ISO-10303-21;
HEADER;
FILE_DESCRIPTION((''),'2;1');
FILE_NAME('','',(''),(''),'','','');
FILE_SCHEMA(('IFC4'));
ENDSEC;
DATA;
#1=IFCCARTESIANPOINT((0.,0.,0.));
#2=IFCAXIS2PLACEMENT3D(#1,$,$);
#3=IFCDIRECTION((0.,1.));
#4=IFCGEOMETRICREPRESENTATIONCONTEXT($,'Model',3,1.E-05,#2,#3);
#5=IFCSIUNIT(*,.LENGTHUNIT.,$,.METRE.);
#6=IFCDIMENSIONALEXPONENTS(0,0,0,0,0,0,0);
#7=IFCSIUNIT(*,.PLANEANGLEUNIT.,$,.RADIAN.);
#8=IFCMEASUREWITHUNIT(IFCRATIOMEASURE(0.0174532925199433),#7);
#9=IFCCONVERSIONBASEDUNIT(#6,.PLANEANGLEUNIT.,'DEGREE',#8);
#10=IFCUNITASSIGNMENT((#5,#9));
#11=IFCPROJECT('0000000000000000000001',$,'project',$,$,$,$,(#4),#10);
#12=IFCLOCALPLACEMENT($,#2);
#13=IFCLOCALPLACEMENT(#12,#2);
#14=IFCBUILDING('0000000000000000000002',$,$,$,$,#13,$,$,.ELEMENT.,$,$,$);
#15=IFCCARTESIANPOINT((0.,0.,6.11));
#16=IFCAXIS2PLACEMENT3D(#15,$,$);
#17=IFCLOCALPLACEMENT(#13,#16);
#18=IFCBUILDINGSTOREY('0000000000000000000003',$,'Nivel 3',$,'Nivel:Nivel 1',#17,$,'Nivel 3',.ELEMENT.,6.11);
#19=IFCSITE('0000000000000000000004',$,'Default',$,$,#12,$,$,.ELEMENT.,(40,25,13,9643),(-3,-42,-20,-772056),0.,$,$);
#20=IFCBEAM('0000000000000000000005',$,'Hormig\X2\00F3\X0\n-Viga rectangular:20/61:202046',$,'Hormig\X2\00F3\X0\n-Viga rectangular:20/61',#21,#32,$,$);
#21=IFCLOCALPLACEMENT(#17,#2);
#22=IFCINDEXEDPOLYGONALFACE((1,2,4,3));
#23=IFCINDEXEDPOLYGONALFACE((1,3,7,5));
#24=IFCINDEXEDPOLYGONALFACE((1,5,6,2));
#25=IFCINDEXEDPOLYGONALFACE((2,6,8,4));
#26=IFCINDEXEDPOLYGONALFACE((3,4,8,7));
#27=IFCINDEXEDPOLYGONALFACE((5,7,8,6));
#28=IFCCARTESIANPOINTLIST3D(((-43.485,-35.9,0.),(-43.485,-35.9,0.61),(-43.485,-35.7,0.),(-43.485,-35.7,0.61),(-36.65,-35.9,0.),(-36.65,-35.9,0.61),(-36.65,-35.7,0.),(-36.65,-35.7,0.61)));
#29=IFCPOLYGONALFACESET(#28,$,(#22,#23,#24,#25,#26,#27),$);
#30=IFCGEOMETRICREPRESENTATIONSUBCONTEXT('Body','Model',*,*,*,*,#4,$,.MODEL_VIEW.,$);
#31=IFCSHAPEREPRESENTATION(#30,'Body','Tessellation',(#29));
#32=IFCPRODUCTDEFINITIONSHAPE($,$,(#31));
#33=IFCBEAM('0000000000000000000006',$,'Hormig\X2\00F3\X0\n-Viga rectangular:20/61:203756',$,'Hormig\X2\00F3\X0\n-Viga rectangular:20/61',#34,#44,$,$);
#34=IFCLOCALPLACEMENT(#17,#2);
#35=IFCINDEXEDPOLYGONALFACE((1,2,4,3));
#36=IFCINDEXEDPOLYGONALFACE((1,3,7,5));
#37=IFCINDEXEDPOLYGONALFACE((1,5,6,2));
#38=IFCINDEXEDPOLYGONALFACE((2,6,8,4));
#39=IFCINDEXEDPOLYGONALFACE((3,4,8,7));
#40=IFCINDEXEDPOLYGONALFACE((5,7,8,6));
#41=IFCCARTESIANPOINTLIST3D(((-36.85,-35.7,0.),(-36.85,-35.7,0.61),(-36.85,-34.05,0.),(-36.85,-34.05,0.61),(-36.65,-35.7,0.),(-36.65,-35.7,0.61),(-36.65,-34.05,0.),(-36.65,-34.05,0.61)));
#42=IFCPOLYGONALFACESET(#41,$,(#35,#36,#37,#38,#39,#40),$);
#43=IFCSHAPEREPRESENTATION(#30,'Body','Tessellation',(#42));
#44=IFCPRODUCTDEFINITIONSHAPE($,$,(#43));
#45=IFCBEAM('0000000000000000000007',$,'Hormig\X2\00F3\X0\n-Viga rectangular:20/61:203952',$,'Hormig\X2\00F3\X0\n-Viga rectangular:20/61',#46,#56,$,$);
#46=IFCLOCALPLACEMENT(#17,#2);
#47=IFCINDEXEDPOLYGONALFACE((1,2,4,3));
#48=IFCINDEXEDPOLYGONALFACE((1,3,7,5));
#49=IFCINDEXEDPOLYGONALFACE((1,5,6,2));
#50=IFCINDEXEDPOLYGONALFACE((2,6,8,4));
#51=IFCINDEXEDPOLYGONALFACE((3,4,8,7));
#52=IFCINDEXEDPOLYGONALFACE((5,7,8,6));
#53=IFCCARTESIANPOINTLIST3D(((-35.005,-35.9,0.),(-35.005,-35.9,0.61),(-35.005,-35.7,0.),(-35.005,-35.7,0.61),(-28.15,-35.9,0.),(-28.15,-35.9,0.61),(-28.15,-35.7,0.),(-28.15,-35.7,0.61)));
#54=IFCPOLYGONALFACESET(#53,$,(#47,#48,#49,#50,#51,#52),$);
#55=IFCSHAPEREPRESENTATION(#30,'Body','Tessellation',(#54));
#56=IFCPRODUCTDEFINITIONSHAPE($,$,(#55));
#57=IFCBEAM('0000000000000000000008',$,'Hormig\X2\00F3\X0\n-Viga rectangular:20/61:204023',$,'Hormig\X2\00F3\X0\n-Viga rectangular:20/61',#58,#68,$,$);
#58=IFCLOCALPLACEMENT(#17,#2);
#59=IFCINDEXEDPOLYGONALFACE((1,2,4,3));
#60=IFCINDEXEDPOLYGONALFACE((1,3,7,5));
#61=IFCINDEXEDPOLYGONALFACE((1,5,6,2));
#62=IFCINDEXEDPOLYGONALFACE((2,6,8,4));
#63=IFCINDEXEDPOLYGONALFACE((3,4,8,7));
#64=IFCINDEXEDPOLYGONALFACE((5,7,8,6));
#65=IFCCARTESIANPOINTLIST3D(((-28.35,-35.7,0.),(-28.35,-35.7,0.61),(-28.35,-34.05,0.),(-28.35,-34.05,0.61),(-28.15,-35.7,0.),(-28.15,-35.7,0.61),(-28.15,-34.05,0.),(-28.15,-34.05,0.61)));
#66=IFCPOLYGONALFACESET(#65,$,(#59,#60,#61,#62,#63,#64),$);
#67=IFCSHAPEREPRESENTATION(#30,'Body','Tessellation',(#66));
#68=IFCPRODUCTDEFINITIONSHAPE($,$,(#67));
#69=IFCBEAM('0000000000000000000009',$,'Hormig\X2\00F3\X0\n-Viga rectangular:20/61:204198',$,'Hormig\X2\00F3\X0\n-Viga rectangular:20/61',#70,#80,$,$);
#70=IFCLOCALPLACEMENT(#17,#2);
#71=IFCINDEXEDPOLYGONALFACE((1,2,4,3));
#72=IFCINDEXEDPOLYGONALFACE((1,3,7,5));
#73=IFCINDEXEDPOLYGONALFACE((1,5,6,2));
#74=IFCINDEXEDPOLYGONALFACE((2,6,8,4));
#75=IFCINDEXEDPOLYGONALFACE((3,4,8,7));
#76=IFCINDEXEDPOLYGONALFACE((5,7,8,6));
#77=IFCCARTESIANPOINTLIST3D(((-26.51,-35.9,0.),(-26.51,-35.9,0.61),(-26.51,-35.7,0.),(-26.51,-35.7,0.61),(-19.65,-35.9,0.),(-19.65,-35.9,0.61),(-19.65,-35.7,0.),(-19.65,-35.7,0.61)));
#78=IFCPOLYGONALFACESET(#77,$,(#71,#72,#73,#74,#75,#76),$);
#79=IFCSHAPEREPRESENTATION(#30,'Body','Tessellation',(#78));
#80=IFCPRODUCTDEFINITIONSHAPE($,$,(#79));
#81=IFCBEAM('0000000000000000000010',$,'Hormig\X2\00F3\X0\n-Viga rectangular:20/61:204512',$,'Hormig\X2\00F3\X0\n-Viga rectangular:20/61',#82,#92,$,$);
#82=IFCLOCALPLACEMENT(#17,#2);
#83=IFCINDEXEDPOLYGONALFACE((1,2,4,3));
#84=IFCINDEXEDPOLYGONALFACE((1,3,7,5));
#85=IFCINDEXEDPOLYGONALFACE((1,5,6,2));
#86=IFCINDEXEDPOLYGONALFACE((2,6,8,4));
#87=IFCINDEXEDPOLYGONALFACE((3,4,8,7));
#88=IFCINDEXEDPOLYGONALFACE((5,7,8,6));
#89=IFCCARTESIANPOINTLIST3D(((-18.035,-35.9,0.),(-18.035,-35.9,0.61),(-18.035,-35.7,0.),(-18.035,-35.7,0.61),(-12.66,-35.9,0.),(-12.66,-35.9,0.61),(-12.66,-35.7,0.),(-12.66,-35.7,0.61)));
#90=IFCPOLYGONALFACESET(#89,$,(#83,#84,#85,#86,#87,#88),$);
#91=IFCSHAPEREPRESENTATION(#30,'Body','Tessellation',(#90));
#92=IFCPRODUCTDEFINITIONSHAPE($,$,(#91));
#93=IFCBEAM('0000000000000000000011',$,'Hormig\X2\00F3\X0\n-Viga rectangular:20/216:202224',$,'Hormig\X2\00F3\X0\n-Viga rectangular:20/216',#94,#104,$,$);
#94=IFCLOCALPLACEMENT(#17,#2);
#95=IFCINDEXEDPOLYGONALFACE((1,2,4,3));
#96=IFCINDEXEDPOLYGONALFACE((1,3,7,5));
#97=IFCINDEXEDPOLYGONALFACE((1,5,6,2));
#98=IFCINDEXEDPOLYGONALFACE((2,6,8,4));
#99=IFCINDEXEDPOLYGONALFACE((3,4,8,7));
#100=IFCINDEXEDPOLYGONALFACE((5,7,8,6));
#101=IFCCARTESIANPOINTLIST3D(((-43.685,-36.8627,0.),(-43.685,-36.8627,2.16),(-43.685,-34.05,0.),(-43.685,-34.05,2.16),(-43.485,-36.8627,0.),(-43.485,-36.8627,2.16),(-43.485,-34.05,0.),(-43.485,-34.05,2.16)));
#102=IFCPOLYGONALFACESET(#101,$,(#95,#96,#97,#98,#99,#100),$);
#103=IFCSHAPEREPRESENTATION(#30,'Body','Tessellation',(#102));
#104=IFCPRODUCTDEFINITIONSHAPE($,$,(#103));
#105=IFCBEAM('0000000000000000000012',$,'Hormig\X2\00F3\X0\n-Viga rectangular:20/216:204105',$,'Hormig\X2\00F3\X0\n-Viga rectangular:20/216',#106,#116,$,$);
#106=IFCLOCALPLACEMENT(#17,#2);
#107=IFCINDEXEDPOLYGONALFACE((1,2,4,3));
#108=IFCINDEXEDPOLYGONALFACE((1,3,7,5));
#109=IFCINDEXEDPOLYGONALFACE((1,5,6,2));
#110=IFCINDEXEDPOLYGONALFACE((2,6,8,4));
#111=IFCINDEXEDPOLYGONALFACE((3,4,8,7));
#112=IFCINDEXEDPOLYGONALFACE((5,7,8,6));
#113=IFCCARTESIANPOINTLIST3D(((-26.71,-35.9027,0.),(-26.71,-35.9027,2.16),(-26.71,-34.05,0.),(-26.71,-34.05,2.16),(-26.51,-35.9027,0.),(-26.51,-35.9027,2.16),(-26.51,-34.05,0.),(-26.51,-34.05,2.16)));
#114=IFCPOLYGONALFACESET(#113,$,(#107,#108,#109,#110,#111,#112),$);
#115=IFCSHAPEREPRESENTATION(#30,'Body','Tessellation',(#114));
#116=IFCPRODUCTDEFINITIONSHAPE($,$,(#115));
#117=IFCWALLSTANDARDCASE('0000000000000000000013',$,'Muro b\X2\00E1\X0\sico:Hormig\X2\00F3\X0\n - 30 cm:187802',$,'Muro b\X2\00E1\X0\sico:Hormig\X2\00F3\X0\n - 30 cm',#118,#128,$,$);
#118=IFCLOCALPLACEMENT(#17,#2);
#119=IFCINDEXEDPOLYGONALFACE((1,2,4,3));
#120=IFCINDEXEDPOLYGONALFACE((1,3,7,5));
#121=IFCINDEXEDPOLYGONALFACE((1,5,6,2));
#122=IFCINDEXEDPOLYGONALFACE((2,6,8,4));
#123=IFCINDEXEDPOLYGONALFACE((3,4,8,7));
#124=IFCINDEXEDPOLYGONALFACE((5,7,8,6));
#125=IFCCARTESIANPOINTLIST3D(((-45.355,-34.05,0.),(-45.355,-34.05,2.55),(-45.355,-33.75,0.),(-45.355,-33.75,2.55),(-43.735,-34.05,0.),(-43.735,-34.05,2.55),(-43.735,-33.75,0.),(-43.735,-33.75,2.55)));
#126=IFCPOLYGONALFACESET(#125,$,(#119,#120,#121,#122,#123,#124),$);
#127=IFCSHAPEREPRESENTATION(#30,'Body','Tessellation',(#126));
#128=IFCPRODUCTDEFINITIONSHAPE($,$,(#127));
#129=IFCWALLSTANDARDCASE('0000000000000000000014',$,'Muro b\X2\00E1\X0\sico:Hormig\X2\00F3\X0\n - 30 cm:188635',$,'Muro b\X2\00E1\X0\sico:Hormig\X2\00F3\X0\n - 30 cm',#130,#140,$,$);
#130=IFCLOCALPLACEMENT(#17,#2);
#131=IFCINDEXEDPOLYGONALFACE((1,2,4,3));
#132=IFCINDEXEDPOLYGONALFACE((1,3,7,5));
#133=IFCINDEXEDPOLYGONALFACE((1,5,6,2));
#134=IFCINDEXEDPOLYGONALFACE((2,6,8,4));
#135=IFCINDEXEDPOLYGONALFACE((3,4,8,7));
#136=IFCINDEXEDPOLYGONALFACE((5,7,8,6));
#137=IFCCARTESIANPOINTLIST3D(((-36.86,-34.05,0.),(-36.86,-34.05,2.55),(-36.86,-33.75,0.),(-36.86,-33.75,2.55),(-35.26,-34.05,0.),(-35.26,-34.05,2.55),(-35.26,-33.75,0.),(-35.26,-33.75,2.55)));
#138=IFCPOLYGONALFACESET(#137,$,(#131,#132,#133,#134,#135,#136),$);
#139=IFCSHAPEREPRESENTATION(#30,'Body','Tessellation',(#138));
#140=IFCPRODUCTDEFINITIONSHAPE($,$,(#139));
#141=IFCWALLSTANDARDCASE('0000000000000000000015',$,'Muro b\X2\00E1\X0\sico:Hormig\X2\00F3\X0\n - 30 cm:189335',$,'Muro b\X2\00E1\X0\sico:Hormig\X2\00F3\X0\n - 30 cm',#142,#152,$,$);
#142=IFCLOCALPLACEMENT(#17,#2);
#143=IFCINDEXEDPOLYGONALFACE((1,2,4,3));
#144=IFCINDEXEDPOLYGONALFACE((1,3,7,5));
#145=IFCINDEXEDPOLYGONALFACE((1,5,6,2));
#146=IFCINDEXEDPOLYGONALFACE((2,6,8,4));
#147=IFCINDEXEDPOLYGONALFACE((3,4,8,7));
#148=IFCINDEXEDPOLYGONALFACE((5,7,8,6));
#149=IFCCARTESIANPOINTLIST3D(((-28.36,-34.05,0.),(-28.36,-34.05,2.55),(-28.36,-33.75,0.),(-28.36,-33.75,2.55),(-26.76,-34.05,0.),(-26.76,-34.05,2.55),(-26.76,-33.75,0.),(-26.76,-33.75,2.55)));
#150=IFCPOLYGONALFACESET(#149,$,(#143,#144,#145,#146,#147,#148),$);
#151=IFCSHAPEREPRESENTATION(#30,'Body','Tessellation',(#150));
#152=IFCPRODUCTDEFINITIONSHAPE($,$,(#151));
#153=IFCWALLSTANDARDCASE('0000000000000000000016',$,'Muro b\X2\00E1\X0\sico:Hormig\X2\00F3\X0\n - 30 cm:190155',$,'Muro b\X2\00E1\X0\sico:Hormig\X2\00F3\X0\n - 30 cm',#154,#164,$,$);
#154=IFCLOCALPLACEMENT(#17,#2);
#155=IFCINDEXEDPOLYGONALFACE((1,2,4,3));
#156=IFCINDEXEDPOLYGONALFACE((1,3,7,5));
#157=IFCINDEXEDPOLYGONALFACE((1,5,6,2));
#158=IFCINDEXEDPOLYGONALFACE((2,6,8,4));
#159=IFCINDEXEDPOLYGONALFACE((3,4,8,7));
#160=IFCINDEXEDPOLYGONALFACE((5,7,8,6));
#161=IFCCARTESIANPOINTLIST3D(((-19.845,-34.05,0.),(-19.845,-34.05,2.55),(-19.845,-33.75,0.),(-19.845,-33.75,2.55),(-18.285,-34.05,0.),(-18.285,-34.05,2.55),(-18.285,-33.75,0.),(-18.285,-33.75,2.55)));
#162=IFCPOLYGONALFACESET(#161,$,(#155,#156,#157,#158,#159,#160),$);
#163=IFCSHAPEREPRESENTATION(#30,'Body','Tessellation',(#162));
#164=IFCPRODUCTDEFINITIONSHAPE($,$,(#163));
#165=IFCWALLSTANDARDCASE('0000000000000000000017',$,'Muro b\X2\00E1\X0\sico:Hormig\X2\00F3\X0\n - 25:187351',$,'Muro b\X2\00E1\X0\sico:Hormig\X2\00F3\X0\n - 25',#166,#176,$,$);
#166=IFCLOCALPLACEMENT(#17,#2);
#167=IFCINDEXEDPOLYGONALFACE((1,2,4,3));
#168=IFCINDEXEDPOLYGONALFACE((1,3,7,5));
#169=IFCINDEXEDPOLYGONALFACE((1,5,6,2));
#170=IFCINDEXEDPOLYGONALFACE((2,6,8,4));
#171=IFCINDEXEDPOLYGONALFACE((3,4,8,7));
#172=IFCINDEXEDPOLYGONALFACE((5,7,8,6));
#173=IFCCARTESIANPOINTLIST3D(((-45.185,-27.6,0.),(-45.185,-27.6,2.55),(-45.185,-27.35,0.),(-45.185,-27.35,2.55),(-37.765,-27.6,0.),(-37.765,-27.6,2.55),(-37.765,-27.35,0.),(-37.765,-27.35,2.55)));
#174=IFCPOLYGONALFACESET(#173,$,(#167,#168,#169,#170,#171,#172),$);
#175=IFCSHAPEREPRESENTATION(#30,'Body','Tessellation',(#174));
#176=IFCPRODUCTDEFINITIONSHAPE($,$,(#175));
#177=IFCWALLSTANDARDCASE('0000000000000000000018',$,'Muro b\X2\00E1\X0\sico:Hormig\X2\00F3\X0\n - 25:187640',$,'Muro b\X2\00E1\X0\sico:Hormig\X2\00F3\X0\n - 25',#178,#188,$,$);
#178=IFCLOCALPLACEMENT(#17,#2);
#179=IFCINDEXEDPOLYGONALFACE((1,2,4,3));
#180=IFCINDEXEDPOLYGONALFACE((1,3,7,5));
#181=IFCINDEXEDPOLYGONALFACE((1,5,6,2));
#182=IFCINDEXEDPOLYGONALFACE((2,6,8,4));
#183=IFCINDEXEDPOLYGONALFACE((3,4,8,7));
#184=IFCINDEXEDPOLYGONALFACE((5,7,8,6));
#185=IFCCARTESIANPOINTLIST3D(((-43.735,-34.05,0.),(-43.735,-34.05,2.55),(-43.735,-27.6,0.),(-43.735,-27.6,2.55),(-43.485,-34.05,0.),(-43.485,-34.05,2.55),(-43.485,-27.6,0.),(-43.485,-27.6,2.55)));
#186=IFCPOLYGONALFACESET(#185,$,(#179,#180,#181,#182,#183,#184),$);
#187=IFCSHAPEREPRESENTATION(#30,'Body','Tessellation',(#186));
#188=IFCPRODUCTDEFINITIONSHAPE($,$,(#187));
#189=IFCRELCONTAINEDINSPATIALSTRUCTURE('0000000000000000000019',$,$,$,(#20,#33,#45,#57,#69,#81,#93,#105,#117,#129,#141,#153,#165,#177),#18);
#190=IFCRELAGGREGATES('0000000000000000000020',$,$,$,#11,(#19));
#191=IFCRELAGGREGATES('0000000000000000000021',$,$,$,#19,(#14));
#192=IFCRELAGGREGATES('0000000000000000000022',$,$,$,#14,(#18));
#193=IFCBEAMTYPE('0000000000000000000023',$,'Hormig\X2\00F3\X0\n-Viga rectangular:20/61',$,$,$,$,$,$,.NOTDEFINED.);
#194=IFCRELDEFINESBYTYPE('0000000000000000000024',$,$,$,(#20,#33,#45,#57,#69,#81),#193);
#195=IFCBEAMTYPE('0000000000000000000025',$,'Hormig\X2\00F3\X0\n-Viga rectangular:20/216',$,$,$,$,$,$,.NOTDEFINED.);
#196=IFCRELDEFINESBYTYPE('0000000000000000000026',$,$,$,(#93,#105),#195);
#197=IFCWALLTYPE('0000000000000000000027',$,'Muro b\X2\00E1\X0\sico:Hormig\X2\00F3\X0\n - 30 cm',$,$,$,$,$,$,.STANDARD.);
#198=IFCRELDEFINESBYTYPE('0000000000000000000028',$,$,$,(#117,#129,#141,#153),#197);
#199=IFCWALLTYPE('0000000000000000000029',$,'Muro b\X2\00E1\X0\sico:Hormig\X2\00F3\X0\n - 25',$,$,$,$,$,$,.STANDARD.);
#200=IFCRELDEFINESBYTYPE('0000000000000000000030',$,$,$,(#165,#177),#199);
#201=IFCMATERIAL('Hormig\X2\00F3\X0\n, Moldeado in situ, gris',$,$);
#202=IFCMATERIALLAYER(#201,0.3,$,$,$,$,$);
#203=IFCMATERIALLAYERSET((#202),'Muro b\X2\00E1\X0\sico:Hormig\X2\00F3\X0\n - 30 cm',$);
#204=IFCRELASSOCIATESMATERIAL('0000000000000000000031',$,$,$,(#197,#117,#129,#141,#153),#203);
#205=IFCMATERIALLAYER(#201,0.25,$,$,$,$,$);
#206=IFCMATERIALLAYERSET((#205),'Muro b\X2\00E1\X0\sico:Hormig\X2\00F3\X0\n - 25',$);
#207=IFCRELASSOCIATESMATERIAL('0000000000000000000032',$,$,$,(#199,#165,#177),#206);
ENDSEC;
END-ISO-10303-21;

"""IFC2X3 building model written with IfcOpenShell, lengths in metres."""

from ifc_helpers import new_model, entity, si_unit, converted_unit, direction, frame, frame_2d, origin, origin_2d_with_axis, place, context, subcontext, project, spatial, rectangle, extrude, material, layer, layer_set, layer_usage, type_object, element, save


model = new_model("IFC2X3")

# Units and contexts
model_context = context("Model", 3, precision=1e-05, world=origin(), true_north=direction((0.0, 1.0)))
body_context = subcontext(model_context, "Body", "Model", "MODEL_VIEW")
ifc_project = project(units=[si_unit("LENGTHUNIT", "METRE"), converted_unit("PLANEANGLEUNIT", "DEGREE", entity("IfcRatioMeasure", 0.0174532925199433), si_unit("PLANEANGLEUNIT", "RADIAN"), dimensions=[0, 0, 0, 0, 0, 0, 0])], contexts=[model_context])

# Site, building, storey
site_placement = place(None, origin())
site = spatial("IfcSite", under=ifc_project, at=site_placement, Name="Default", CompositionType="ELEMENT", RefLatitude=(40, 25, 13, 9643), RefLongitude=(-3, -42, -20, -772056), RefElevation=0.0)
building_placement = place(site_placement, origin())
building = spatial("IfcBuilding", under=site, at=building_placement, CompositionType="ELEMENT")
storey_placement = place(building_placement, frame((0.0, 0.0, 6.11)))
storey = spatial("IfcBuildingStorey", under=building, at=storey_placement, Name="Nivel 3", ObjectType="Nivel:Nivel 1", LongName="Nivel 3", CompositionType="ELEMENT", Elevation=6.11)

# Beams
beam_type_1 = type_object("IfcBeamType", Name="Hormigón-Viga rectangular:20/61", PredefinedType="NOTDEFINED")
beam_1_placement = place(storey_placement, frame((-43.585, -35.8, 0.61)))
element("IfcBeam", 1, at=beam_1_placement, inside=storey, type_object=beam_type_1, Name="Hormigón-Viga rectangular:20/61:202046", ObjectType="Hormigón-Viga rectangular:20/61", context=body_context, shape_type="SweptSolid", body=[
    extrude(rectangle(XDim=0.61, YDim=0.2, at=frame_2d((0.0, 0.0), x_axis=(1.0, 0.0))), frame((0.1, 0.0, -0.305), z_axis=(1.0, 0.0, 0.0), x_axis=(0.0, 0.0, -1.0)), (0.0, 0.0, 1.0), 6.835),
])
beam_2_placement = place(storey_placement, frame((-36.75, -35.8, 0.61), z_axis=(0.0, 0.0, 1.0), x_axis=(0.0, 1.0, 0.0)))
element("IfcBeam", 2, at=beam_2_placement, inside=storey, type_object=beam_type_1, Name="Hormigón-Viga rectangular:20/61:203756", ObjectType="Hormigón-Viga rectangular:20/61", context=body_context, shape_type="SweptSolid", body=[
    extrude(rectangle(XDim=0.61, YDim=0.2, at=frame_2d((0.0, 0.0), x_axis=(1.0, 0.0))), frame((0.1, 0.0, -0.305), z_axis=(1.0, 0.0, 0.0), x_axis=(0.0, 0.0, -1.0)), (0.0, 0.0, 1.0), 1.65),
])
beam_3_placement = place(storey_placement, frame((-35.105, -35.8, 0.61)))
element("IfcBeam", 3, at=beam_3_placement, inside=storey, type_object=beam_type_1, Name="Hormigón-Viga rectangular:20/61:203952", ObjectType="Hormigón-Viga rectangular:20/61", context=body_context, shape_type="SweptSolid", body=[
    extrude(rectangle(XDim=0.61, YDim=0.2, at=frame_2d((0.0, 0.0), x_axis=(1.0, 0.0))), frame((0.1, 0.0, -0.305), z_axis=(1.0, 0.0, 0.0), x_axis=(0.0, 0.0, -1.0)), (0.0, 0.0, 1.0), 6.855),
])
beam_4_placement = place(storey_placement, frame((-28.25, -35.8, 0.61), z_axis=(0.0, 0.0, 1.0), x_axis=(0.0, 1.0, 0.0)))
element("IfcBeam", 4, at=beam_4_placement, inside=storey, type_object=beam_type_1, Name="Hormigón-Viga rectangular:20/61:204023", ObjectType="Hormigón-Viga rectangular:20/61", context=body_context, shape_type="SweptSolid", body=[
    extrude(rectangle(XDim=0.61, YDim=0.2, at=frame_2d((0.0, 0.0), x_axis=(1.0, 0.0))), frame((0.1, 0.0, -0.305), z_axis=(1.0, 0.0, 0.0), x_axis=(0.0, 0.0, -1.0)), (0.0, 0.0, 1.0), 1.65),
])
beam_5_placement = place(storey_placement, frame((-26.5857, -35.8, 0.61)))
element("IfcBeam", 5, at=beam_5_placement, inside=storey, type_object=beam_type_1, Name="Hormigón-Viga rectangular:20/61:204198", ObjectType="Hormigón-Viga rectangular:20/61", context=body_context, shape_type="SweptSolid", body=[
    extrude(rectangle(XDim=0.61, YDim=0.2, at=frame_2d((0.0, 0.0), x_axis=(1.0, 0.0))), frame((0.0757, 0.0, -0.305), z_axis=(1.0, 0.0, 0.0), x_axis=(0.0, 0.0, -1.0)), (0.0, 0.0, 1.0), 6.86),
])
beam_6_placement = place(storey_placement, frame((-18.1107, -35.8, 0.61)))
element("IfcBeam", 6, at=beam_6_placement, inside=storey, type_object=beam_type_1, Name="Hormigón-Viga rectangular:20/61:204512", ObjectType="Hormigón-Viga rectangular:20/61", context=body_context, shape_type="SweptSolid", body=[
    extrude(rectangle(XDim=0.61, YDim=0.2, at=frame_2d((0.0, 0.0), x_axis=(1.0, 0.0))), frame((0.0757, 0.0, -0.305), z_axis=(1.0, 0.0, 0.0), x_axis=(0.0, 0.0, -1.0)), (0.0, 0.0, 1.0), 5.375),
])
beam_type_2 = type_object("IfcBeamType", Name="Hormigón-Viga rectangular:20/216", PredefinedType="NOTDEFINED")
beam_7_placement = place(storey_placement, frame((-43.585, -36.85, 2.16), z_axis=(0.0, 0.0, 1.0), x_axis=(0.0, 1.0, 0.0)))
element("IfcBeam", 7, at=beam_7_placement, inside=storey, type_object=beam_type_2, Name="Hormigón-Viga rectangular:20/216:202224", ObjectType="Hormigón-Viga rectangular:20/216", context=body_context, shape_type="SweptSolid", body=[
    extrude(rectangle(XDim=2.16, YDim=0.2, at=origin_2d_with_axis()), frame((-0.0127, 0.0, -1.08), z_axis=(1.0, 0.0, 0.0), x_axis=(0.0, 0.0, -1.0)), (0.0, 0.0, 1.0), 2.8127),
])
beam_8_placement = place(storey_placement, frame((-26.61, -35.89, 2.16), z_axis=(0.0, 0.0, 1.0), x_axis=(0.0, 1.0, 0.0)))
element("IfcBeam", 8, at=beam_8_placement, inside=storey, type_object=beam_type_2, Name="Hormigón-Viga rectangular:20/216:204105", ObjectType="Hormigón-Viga rectangular:20/216", context=body_context, shape_type="SweptSolid", body=[
    extrude(rectangle(XDim=2.16, YDim=0.2, at=frame_2d((0.0, 0.0), x_axis=(1.0, 0.0))), frame((-0.0127, 0.0, -1.08), z_axis=(1.0, 0.0, 0.0), x_axis=(0.0, 0.0, -1.0)), (0.0, 0.0, 1.0), 1.8527),
])

# Walls
ifc_material = material(Name="Hormigón, Moldeado in situ, gris")
ifc_layer_1 = layer(ifc_material, 0.3)
ifc_layer_set_1 = layer_set([ifc_layer_1], Name="Muro básico:Hormigón - 30 cm")
ifc_layer_usage_1 = layer_usage(ifc_layer_set_1, "AXIS2", "NEGATIVE", 0.15)
wall_type_1 = type_object("IfcWallType", Name="Muro básico:Hormigón - 30 cm", PredefinedType="STANDARD", material=ifc_layer_set_1)
wall_1_placement = place(storey_placement, frame((-43.735, -33.9, 0.0), z_axis=(0.0, 0.0, 1.0), x_axis=(-1.0, 0.0, 0.0)))
element("IfcWallStandardCase", 9, at=wall_1_placement, inside=storey, type_object=wall_type_1, material=ifc_layer_usage_1, Name="Muro básico:Hormigón - 30 cm:187802", ObjectType="Muro básico:Hormigón - 30 cm", context=body_context, shape_type="SweptSolid", body=[
    extrude(rectangle(XDim=1.62, YDim=0.3, at=frame_2d((0.81, 0.0), x_axis=(-1.0, 0.0))), origin(), (0.0, 0.0, 1.0), 2.55),
])
ifc_layer_usage_2 = layer_usage(ifc_layer_set_1, "AXIS2", "NEGATIVE", 0.15)
wall_2_placement = place(storey_placement, frame((-35.26, -33.9, 0.0), z_axis=(0.0, 0.0, 1.0), x_axis=(-1.0, 0.0, 0.0)))
element("IfcWallStandardCase", 10, at=wall_2_placement, inside=storey, type_object=wall_type_1, material=ifc_layer_usage_2, Name="Muro básico:Hormigón - 30 cm:188635", ObjectType="Muro básico:Hormigón - 30 cm", context=body_context, shape_type="SweptSolid", body=[
    extrude(rectangle(XDim=1.6, YDim=0.3, at=frame_2d((0.8, 0.0), x_axis=(-1.0, 0.0))), origin(), (0.0, 0.0, 1.0), 2.55),
])
ifc_layer_usage_3 = layer_usage(ifc_layer_set_1, "AXIS2", "NEGATIVE", 0.15)
wall_3_placement = place(storey_placement, frame((-26.76, -33.9, 0.0), z_axis=(0.0, 0.0, 1.0), x_axis=(-1.0, 0.0, 0.0)))
element("IfcWallStandardCase", 11, at=wall_3_placement, inside=storey, type_object=wall_type_1, material=ifc_layer_usage_3, Name="Muro básico:Hormigón - 30 cm:189335", ObjectType="Muro básico:Hormigón - 30 cm", context=body_context, shape_type="SweptSolid", body=[
    extrude(rectangle(XDim=1.6, YDim=0.3, at=frame_2d((0.8, 0.0), x_axis=(-1.0, 0.0))), origin(), (0.0, 0.0, 1.0), 2.55),
])
ifc_layer_usage_4 = layer_usage(ifc_layer_set_1, "AXIS2", "NEGATIVE", 0.15)
wall_4_placement = place(storey_placement, frame((-18.285, -33.9, 0.0), z_axis=(0.0, 0.0, 1.0), x_axis=(-1.0, 0.0, 0.0)))
element("IfcWallStandardCase", 12, at=wall_4_placement, inside=storey, type_object=wall_type_1, material=ifc_layer_usage_4, Name="Muro básico:Hormigón - 30 cm:190155", ObjectType="Muro básico:Hormigón - 30 cm", context=body_context, shape_type="SweptSolid", body=[
    extrude(rectangle(XDim=1.56, YDim=0.3, at=frame_2d((0.78, 0.0), x_axis=(-1.0, 0.0))), origin(), (0.0, 0.0, 1.0), 2.55),
])
ifc_layer_2 = layer(ifc_material, 0.25)
ifc_layer_set_2 = layer_set([ifc_layer_2], Name="Muro básico:Hormigón - 25")
ifc_layer_usage_5 = layer_usage(ifc_layer_set_2, "AXIS2", "NEGATIVE", 0.125)
wall_type_2 = type_object("IfcWallType", Name="Muro básico:Hormigón - 25", PredefinedType="STANDARD", material=ifc_layer_set_2)
wall_5_placement = place(storey_placement, frame((-45.185, -27.475, 0.0)))
element("IfcWallStandardCase", 13, at=wall_5_placement, inside=storey, type_object=wall_type_2, material=ifc_layer_usage_5, Name="Muro básico:Hormigón - 25:187351", ObjectType="Muro básico:Hormigón - 25", context=body_context, shape_type="SweptSolid", body=[
    extrude(rectangle(XDim=7.42, YDim=0.25, at=frame_2d((3.71, 0.0), x_axis=(-1.0, 0.0))), origin(), (0.0, 0.0, 1.0), 2.55),
])
ifc_layer_usage_6 = layer_usage(ifc_layer_set_2, "AXIS2", "NEGATIVE", 0.125)
wall_6_placement = place(storey_placement, frame((-43.61, -27.6, 0.0), z_axis=(0.0, 0.0, 1.0), x_axis=(0.0, -1.0, 0.0)))
element("IfcWallStandardCase", 14, at=wall_6_placement, inside=storey, type_object=wall_type_2, material=ifc_layer_usage_6, Name="Muro básico:Hormigón - 25:187640", ObjectType="Muro básico:Hormigón - 25", context=body_context, shape_type="SweptSolid", body=[
    extrude(rectangle(XDim=6.45, YDim=0.25, at=frame_2d((3.225, 0.0), x_axis=(-1.0, 0.0))), origin(), (0.0, 0.0, 1.0), 2.55),
])

save(model, "model.ifc")
